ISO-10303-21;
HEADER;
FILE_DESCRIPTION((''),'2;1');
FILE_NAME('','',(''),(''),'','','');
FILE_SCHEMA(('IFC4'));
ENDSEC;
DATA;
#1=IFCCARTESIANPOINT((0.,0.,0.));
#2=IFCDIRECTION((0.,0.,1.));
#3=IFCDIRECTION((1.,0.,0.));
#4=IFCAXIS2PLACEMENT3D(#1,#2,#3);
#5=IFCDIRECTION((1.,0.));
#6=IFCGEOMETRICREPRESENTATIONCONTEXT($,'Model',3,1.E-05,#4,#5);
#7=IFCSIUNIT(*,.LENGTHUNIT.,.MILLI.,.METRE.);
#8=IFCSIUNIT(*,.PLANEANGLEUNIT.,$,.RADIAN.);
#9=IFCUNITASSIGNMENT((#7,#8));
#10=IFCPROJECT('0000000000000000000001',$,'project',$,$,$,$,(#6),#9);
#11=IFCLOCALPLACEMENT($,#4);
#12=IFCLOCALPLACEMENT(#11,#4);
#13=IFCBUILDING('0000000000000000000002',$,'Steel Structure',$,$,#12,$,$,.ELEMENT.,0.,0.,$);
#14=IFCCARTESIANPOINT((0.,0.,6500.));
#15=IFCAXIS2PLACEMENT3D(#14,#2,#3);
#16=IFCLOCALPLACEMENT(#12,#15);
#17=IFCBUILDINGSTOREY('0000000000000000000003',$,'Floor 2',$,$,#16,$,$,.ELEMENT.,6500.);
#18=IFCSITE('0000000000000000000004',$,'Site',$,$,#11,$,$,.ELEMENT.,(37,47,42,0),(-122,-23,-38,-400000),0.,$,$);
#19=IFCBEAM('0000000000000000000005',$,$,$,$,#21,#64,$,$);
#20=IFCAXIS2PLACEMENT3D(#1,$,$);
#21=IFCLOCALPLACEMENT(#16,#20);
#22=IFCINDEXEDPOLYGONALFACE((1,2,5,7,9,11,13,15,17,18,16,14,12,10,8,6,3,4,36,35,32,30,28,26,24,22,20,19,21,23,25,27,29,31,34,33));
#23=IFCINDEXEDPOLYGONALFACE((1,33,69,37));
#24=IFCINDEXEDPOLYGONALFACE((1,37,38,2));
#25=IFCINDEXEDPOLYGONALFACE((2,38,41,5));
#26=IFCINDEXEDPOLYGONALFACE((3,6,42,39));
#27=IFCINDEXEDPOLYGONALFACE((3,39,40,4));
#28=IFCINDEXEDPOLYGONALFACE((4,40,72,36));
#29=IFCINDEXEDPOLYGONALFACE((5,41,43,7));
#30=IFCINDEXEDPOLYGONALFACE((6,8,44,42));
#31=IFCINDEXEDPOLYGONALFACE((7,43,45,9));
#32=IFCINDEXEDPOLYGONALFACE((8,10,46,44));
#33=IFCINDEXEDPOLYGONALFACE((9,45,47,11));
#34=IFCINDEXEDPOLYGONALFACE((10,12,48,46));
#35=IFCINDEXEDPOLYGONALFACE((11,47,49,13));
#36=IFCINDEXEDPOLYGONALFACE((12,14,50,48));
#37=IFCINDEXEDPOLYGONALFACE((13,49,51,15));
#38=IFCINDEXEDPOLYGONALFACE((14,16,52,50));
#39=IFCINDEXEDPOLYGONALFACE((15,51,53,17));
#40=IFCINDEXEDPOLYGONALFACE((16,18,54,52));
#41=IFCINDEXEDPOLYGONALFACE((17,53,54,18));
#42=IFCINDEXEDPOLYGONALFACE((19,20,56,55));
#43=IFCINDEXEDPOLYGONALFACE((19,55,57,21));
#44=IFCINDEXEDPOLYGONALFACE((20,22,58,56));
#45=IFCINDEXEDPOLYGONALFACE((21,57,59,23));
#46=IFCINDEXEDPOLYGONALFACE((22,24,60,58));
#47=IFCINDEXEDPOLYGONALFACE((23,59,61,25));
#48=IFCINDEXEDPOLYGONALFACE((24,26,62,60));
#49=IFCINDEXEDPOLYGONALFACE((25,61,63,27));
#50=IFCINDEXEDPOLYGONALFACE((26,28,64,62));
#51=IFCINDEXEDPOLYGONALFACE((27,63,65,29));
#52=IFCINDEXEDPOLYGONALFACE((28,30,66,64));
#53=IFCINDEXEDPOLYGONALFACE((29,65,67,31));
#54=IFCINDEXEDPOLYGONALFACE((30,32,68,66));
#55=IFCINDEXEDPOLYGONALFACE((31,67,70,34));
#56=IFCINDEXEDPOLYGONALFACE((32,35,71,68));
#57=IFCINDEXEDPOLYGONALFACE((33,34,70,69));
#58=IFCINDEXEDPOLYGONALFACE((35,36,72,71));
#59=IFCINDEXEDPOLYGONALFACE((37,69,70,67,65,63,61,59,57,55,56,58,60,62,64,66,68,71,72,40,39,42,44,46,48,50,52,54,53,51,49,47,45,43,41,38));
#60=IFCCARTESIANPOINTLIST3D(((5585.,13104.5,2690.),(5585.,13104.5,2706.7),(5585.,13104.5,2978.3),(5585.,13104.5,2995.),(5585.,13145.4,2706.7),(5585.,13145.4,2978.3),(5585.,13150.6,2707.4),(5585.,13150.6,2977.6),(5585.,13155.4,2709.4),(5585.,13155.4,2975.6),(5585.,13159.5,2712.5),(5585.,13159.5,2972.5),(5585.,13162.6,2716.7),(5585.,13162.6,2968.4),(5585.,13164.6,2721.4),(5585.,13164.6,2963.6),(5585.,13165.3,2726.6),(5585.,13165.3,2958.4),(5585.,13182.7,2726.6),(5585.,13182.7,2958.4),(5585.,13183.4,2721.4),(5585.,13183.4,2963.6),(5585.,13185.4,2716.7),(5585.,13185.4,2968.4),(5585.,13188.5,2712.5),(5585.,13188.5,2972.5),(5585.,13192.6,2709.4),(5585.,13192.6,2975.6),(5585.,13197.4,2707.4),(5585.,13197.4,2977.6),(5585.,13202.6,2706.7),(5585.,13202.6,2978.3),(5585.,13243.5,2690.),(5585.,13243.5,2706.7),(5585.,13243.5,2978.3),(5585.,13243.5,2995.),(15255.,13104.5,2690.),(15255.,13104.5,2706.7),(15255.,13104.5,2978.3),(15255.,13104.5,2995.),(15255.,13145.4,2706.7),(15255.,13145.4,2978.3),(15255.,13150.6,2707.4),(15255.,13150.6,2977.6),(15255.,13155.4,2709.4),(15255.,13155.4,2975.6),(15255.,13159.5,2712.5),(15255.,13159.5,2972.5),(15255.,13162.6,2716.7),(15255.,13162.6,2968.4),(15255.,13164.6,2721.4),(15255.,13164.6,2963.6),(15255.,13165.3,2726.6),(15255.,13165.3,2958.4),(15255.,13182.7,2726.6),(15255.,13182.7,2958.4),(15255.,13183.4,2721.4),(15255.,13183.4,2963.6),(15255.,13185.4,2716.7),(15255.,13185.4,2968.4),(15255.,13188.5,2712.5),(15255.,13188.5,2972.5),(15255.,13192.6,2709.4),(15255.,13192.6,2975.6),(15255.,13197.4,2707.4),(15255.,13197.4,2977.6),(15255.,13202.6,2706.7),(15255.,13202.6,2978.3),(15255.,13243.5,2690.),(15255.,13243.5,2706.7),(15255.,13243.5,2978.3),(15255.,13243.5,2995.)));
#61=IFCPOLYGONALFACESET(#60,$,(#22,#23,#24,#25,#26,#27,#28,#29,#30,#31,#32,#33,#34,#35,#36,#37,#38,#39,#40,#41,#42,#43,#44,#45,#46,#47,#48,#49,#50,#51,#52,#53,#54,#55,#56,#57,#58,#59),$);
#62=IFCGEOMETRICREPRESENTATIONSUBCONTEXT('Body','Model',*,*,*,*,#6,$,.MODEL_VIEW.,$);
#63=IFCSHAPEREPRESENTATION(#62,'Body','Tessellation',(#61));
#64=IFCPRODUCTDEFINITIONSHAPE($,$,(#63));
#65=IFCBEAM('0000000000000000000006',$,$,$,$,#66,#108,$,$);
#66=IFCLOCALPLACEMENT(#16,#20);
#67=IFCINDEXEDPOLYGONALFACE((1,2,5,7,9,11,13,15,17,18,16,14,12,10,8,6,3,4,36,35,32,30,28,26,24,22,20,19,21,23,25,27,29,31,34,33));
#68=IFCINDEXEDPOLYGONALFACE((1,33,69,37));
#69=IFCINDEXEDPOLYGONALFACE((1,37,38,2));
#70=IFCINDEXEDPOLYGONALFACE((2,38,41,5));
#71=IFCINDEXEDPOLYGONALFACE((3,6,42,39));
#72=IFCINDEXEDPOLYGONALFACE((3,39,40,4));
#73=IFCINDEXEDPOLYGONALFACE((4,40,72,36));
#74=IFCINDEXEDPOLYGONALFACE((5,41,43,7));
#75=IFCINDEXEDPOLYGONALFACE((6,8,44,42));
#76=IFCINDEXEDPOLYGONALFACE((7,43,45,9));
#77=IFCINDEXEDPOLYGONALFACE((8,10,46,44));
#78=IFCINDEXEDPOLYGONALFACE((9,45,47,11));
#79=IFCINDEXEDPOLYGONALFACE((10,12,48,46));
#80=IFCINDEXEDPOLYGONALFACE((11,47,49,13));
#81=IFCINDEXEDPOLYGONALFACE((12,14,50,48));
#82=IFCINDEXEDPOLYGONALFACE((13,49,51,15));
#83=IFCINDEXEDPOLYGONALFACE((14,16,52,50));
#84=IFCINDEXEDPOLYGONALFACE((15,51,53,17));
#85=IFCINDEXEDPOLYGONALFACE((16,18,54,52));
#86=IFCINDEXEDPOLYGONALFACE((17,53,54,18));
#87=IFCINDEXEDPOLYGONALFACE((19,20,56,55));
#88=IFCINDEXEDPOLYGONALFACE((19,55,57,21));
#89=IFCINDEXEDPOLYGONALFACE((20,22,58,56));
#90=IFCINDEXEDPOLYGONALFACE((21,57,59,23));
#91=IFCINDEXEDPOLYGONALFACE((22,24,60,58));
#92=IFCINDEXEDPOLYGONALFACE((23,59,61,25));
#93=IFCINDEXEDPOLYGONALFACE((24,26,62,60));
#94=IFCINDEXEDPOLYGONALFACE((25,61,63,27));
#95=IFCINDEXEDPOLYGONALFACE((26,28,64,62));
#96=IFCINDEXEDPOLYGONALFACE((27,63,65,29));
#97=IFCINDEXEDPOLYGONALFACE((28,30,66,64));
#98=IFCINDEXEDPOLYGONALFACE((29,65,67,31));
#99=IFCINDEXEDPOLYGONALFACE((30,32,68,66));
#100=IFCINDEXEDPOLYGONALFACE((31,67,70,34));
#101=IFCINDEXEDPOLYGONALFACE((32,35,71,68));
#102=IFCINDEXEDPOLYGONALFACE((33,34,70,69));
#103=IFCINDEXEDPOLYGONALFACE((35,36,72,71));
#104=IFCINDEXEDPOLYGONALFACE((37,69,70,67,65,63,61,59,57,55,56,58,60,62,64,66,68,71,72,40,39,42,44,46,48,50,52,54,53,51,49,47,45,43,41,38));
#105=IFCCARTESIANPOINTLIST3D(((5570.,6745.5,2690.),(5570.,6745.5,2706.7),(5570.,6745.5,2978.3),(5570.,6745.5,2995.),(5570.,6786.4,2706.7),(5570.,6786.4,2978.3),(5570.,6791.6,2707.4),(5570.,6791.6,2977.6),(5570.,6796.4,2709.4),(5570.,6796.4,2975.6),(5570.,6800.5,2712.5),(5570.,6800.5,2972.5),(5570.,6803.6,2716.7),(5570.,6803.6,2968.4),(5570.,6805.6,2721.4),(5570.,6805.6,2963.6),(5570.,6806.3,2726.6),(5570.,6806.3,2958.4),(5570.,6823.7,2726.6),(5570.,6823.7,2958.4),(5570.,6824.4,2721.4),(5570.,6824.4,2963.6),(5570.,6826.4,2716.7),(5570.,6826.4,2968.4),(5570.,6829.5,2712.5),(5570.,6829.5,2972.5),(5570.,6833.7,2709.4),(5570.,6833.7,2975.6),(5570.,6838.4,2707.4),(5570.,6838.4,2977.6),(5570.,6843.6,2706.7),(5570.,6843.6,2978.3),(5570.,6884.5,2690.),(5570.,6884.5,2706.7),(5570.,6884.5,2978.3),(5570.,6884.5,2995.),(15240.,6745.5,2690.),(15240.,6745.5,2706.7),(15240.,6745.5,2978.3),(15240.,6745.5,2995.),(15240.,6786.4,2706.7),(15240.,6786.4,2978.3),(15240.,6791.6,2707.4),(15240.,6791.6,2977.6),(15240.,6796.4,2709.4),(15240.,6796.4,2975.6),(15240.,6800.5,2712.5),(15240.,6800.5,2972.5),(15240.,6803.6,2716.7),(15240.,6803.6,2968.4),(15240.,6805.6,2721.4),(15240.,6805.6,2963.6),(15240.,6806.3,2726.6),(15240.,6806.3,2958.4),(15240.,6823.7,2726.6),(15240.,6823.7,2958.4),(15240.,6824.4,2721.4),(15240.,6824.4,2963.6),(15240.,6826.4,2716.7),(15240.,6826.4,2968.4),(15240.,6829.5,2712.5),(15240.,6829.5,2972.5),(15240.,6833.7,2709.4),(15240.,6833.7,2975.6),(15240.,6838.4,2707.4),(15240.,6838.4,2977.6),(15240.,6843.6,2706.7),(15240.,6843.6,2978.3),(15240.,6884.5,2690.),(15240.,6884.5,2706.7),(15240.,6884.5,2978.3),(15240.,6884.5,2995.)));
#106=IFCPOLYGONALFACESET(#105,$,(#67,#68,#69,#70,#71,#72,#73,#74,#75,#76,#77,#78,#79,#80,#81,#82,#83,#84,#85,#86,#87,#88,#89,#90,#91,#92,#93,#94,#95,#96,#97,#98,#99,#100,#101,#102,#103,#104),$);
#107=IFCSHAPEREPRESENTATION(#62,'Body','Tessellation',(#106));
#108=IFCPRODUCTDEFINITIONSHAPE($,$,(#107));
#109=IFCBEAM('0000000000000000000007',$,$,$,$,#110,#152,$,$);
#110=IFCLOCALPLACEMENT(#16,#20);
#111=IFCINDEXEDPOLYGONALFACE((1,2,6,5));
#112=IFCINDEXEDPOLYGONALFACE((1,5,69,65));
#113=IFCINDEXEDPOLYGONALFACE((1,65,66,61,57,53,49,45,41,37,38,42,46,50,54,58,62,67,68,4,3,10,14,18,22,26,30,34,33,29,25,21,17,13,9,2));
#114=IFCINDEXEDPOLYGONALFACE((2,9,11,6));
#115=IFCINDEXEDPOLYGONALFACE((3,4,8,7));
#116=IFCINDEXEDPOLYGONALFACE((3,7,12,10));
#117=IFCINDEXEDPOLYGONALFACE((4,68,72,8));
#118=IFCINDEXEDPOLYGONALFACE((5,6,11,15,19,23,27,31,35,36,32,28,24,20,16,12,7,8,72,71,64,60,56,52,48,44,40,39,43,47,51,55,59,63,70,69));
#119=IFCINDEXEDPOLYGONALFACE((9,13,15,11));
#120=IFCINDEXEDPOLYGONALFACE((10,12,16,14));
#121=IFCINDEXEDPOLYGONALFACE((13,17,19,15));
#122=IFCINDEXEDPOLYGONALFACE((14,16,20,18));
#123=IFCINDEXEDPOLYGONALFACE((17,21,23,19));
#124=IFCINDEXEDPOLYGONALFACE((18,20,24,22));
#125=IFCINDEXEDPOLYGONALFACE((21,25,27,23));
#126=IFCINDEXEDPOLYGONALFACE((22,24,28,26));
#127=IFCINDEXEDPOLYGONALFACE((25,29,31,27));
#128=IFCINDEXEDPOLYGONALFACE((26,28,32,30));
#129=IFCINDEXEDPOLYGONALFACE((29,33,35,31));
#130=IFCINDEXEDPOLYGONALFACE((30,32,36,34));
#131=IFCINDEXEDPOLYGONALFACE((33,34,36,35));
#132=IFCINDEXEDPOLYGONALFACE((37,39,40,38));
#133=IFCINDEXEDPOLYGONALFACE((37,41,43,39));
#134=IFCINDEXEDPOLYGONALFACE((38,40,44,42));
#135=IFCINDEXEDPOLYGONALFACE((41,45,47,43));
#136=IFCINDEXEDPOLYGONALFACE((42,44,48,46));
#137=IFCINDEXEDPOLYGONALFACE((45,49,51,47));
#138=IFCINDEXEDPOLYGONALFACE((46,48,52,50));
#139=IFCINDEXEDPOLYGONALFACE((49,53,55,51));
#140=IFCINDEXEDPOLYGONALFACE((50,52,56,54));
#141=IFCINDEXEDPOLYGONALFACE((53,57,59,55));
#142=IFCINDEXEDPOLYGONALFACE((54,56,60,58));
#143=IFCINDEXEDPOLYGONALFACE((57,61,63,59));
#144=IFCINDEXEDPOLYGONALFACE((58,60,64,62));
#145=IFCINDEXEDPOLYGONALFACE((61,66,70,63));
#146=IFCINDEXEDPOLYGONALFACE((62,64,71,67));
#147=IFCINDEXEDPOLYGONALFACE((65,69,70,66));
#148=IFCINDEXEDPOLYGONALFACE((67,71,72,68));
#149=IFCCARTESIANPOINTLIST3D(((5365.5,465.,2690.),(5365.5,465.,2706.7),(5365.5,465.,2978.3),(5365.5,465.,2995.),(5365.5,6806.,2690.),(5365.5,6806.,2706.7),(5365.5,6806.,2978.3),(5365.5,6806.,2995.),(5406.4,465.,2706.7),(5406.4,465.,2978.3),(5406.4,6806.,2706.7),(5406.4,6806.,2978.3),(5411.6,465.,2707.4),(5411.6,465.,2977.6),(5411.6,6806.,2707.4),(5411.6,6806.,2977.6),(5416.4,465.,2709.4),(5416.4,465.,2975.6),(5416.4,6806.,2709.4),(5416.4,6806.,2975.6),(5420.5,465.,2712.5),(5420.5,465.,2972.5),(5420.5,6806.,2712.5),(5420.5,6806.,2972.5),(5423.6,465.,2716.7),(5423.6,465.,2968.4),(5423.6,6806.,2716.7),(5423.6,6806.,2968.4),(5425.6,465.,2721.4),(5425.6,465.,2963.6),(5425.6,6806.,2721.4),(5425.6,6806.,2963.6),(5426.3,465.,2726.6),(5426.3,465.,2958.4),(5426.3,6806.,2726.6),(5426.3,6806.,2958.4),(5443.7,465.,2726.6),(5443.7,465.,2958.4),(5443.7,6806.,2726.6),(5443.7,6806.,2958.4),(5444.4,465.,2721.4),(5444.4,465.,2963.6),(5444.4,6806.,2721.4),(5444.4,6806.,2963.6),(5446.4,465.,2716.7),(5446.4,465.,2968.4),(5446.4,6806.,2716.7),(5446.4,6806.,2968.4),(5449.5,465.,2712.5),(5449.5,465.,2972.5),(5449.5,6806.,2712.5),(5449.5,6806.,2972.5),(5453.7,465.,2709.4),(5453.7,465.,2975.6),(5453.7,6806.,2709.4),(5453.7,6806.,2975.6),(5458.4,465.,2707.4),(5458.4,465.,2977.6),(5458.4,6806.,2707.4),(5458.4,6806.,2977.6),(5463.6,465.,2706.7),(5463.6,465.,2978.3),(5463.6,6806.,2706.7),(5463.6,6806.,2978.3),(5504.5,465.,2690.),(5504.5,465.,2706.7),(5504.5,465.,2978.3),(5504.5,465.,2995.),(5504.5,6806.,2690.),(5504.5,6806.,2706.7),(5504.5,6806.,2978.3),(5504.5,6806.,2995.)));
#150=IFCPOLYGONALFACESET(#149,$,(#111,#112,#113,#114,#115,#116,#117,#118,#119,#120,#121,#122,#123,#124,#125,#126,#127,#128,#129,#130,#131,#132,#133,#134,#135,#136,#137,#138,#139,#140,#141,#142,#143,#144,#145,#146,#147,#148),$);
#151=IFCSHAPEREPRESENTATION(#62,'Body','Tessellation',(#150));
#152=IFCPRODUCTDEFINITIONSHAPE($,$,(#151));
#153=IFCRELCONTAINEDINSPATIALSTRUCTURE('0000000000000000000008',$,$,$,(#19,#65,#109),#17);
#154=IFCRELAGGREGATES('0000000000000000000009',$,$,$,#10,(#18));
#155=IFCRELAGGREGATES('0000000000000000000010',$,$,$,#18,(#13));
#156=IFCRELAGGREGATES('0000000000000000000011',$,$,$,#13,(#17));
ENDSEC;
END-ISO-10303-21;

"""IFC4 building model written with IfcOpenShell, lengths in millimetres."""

from ifc_helpers import new_model, si_unit, direction, frame, origin_with_axes, origin_2d_with_axis, place, context, subcontext, project, spatial, i_section, extrude, element, save


model = new_model("IFC4")

# Units and contexts
model_context = context("Model", 3, precision=1e-05, world=origin_with_axes(), true_north=direction((1.0, 0.0)))
body_context = subcontext(model_context, "Body", "Model", "MODEL_VIEW")
ifc_project = project(units=[si_unit("LENGTHUNIT", "METRE", prefix="MILLI"), si_unit("PLANEANGLEUNIT", "RADIAN")], contexts=[model_context])

# Site, building, storey
site_placement = place(None, origin_with_axes())
site = spatial("IfcSite", under=ifc_project, at=site_placement, Name="Site", CompositionType="ELEMENT", RefLatitude=(37, 47, 42, 0), RefLongitude=(-122, -23, -38, -400000), RefElevation=0.0)
building_placement = place(site_placement, origin_with_axes())
building = spatial("IfcBuilding", under=site, at=building_placement, Name="Steel Structure", CompositionType="ELEMENT", ElevationOfRefHeight=0.0, ElevationOfTerrain=0.0)
storey_placement = place(building_placement, frame((0.0, 0.0, 6500.0), z_axis=(0.0, 0.0, 1.0), x_axis=(1.0, 0.0, 0.0)))
storey = spatial("IfcBuildingStorey", under=building, at=storey_placement, Name="Floor 2", CompositionType="ELEMENT", Elevation=6500.0)

# Beams
for number, where, z_axis, x_axis in (
    (1, (5585.0, 13174.0, 2690.0), (1.0, 0.0, 0.0), (0.0, 1.0, 0.0)),
    (2, (15240.0, 6815.0, 2690.0), (-1.0, 0.0, 0.0), (0.0, -1.0, 0.0)),
):
    element("IfcBeam", number, at=place(storey_placement, frame(where, z_axis=z_axis, x_axis=x_axis)), inside=storey, context=body_context, shape_type="SweptSolid", body=[
        extrude(i_section(OverallWidth=139.0, OverallDepth=305.0, WebThickness=17.4, FlangeThickness=16.7, FilletRadius=19.9, at=origin_2d_with_axis()), frame((0.0, 152.5, 0.0), z_axis=(0.0, 0.0, 1.0), x_axis=(1.0, 0.0, 0.0)), (0.0, 0.0, 1.0), 9670.0),
    ])
beam_1_placement = place(storey_placement, frame((5435.0, 465.0, 2690.0), z_axis=(0.0, 1.0, 0.0), x_axis=(-1.0, 0.0, 0.0)))
element("IfcBeam", 3, at=beam_1_placement, inside=storey, context=body_context, shape_type="SweptSolid", body=[
    extrude(i_section(OverallWidth=139.0, OverallDepth=305.0, WebThickness=17.4, FlangeThickness=16.7, FilletRadius=19.9, at=origin_2d_with_axis()), frame((0.0, 152.5, 0.0), z_axis=(0.0, 0.0, 1.0), x_axis=(1.0, 0.0, 0.0)), (0.0, 0.0, 1.0), 6341.0),
])

save(model, "model.ifc")
